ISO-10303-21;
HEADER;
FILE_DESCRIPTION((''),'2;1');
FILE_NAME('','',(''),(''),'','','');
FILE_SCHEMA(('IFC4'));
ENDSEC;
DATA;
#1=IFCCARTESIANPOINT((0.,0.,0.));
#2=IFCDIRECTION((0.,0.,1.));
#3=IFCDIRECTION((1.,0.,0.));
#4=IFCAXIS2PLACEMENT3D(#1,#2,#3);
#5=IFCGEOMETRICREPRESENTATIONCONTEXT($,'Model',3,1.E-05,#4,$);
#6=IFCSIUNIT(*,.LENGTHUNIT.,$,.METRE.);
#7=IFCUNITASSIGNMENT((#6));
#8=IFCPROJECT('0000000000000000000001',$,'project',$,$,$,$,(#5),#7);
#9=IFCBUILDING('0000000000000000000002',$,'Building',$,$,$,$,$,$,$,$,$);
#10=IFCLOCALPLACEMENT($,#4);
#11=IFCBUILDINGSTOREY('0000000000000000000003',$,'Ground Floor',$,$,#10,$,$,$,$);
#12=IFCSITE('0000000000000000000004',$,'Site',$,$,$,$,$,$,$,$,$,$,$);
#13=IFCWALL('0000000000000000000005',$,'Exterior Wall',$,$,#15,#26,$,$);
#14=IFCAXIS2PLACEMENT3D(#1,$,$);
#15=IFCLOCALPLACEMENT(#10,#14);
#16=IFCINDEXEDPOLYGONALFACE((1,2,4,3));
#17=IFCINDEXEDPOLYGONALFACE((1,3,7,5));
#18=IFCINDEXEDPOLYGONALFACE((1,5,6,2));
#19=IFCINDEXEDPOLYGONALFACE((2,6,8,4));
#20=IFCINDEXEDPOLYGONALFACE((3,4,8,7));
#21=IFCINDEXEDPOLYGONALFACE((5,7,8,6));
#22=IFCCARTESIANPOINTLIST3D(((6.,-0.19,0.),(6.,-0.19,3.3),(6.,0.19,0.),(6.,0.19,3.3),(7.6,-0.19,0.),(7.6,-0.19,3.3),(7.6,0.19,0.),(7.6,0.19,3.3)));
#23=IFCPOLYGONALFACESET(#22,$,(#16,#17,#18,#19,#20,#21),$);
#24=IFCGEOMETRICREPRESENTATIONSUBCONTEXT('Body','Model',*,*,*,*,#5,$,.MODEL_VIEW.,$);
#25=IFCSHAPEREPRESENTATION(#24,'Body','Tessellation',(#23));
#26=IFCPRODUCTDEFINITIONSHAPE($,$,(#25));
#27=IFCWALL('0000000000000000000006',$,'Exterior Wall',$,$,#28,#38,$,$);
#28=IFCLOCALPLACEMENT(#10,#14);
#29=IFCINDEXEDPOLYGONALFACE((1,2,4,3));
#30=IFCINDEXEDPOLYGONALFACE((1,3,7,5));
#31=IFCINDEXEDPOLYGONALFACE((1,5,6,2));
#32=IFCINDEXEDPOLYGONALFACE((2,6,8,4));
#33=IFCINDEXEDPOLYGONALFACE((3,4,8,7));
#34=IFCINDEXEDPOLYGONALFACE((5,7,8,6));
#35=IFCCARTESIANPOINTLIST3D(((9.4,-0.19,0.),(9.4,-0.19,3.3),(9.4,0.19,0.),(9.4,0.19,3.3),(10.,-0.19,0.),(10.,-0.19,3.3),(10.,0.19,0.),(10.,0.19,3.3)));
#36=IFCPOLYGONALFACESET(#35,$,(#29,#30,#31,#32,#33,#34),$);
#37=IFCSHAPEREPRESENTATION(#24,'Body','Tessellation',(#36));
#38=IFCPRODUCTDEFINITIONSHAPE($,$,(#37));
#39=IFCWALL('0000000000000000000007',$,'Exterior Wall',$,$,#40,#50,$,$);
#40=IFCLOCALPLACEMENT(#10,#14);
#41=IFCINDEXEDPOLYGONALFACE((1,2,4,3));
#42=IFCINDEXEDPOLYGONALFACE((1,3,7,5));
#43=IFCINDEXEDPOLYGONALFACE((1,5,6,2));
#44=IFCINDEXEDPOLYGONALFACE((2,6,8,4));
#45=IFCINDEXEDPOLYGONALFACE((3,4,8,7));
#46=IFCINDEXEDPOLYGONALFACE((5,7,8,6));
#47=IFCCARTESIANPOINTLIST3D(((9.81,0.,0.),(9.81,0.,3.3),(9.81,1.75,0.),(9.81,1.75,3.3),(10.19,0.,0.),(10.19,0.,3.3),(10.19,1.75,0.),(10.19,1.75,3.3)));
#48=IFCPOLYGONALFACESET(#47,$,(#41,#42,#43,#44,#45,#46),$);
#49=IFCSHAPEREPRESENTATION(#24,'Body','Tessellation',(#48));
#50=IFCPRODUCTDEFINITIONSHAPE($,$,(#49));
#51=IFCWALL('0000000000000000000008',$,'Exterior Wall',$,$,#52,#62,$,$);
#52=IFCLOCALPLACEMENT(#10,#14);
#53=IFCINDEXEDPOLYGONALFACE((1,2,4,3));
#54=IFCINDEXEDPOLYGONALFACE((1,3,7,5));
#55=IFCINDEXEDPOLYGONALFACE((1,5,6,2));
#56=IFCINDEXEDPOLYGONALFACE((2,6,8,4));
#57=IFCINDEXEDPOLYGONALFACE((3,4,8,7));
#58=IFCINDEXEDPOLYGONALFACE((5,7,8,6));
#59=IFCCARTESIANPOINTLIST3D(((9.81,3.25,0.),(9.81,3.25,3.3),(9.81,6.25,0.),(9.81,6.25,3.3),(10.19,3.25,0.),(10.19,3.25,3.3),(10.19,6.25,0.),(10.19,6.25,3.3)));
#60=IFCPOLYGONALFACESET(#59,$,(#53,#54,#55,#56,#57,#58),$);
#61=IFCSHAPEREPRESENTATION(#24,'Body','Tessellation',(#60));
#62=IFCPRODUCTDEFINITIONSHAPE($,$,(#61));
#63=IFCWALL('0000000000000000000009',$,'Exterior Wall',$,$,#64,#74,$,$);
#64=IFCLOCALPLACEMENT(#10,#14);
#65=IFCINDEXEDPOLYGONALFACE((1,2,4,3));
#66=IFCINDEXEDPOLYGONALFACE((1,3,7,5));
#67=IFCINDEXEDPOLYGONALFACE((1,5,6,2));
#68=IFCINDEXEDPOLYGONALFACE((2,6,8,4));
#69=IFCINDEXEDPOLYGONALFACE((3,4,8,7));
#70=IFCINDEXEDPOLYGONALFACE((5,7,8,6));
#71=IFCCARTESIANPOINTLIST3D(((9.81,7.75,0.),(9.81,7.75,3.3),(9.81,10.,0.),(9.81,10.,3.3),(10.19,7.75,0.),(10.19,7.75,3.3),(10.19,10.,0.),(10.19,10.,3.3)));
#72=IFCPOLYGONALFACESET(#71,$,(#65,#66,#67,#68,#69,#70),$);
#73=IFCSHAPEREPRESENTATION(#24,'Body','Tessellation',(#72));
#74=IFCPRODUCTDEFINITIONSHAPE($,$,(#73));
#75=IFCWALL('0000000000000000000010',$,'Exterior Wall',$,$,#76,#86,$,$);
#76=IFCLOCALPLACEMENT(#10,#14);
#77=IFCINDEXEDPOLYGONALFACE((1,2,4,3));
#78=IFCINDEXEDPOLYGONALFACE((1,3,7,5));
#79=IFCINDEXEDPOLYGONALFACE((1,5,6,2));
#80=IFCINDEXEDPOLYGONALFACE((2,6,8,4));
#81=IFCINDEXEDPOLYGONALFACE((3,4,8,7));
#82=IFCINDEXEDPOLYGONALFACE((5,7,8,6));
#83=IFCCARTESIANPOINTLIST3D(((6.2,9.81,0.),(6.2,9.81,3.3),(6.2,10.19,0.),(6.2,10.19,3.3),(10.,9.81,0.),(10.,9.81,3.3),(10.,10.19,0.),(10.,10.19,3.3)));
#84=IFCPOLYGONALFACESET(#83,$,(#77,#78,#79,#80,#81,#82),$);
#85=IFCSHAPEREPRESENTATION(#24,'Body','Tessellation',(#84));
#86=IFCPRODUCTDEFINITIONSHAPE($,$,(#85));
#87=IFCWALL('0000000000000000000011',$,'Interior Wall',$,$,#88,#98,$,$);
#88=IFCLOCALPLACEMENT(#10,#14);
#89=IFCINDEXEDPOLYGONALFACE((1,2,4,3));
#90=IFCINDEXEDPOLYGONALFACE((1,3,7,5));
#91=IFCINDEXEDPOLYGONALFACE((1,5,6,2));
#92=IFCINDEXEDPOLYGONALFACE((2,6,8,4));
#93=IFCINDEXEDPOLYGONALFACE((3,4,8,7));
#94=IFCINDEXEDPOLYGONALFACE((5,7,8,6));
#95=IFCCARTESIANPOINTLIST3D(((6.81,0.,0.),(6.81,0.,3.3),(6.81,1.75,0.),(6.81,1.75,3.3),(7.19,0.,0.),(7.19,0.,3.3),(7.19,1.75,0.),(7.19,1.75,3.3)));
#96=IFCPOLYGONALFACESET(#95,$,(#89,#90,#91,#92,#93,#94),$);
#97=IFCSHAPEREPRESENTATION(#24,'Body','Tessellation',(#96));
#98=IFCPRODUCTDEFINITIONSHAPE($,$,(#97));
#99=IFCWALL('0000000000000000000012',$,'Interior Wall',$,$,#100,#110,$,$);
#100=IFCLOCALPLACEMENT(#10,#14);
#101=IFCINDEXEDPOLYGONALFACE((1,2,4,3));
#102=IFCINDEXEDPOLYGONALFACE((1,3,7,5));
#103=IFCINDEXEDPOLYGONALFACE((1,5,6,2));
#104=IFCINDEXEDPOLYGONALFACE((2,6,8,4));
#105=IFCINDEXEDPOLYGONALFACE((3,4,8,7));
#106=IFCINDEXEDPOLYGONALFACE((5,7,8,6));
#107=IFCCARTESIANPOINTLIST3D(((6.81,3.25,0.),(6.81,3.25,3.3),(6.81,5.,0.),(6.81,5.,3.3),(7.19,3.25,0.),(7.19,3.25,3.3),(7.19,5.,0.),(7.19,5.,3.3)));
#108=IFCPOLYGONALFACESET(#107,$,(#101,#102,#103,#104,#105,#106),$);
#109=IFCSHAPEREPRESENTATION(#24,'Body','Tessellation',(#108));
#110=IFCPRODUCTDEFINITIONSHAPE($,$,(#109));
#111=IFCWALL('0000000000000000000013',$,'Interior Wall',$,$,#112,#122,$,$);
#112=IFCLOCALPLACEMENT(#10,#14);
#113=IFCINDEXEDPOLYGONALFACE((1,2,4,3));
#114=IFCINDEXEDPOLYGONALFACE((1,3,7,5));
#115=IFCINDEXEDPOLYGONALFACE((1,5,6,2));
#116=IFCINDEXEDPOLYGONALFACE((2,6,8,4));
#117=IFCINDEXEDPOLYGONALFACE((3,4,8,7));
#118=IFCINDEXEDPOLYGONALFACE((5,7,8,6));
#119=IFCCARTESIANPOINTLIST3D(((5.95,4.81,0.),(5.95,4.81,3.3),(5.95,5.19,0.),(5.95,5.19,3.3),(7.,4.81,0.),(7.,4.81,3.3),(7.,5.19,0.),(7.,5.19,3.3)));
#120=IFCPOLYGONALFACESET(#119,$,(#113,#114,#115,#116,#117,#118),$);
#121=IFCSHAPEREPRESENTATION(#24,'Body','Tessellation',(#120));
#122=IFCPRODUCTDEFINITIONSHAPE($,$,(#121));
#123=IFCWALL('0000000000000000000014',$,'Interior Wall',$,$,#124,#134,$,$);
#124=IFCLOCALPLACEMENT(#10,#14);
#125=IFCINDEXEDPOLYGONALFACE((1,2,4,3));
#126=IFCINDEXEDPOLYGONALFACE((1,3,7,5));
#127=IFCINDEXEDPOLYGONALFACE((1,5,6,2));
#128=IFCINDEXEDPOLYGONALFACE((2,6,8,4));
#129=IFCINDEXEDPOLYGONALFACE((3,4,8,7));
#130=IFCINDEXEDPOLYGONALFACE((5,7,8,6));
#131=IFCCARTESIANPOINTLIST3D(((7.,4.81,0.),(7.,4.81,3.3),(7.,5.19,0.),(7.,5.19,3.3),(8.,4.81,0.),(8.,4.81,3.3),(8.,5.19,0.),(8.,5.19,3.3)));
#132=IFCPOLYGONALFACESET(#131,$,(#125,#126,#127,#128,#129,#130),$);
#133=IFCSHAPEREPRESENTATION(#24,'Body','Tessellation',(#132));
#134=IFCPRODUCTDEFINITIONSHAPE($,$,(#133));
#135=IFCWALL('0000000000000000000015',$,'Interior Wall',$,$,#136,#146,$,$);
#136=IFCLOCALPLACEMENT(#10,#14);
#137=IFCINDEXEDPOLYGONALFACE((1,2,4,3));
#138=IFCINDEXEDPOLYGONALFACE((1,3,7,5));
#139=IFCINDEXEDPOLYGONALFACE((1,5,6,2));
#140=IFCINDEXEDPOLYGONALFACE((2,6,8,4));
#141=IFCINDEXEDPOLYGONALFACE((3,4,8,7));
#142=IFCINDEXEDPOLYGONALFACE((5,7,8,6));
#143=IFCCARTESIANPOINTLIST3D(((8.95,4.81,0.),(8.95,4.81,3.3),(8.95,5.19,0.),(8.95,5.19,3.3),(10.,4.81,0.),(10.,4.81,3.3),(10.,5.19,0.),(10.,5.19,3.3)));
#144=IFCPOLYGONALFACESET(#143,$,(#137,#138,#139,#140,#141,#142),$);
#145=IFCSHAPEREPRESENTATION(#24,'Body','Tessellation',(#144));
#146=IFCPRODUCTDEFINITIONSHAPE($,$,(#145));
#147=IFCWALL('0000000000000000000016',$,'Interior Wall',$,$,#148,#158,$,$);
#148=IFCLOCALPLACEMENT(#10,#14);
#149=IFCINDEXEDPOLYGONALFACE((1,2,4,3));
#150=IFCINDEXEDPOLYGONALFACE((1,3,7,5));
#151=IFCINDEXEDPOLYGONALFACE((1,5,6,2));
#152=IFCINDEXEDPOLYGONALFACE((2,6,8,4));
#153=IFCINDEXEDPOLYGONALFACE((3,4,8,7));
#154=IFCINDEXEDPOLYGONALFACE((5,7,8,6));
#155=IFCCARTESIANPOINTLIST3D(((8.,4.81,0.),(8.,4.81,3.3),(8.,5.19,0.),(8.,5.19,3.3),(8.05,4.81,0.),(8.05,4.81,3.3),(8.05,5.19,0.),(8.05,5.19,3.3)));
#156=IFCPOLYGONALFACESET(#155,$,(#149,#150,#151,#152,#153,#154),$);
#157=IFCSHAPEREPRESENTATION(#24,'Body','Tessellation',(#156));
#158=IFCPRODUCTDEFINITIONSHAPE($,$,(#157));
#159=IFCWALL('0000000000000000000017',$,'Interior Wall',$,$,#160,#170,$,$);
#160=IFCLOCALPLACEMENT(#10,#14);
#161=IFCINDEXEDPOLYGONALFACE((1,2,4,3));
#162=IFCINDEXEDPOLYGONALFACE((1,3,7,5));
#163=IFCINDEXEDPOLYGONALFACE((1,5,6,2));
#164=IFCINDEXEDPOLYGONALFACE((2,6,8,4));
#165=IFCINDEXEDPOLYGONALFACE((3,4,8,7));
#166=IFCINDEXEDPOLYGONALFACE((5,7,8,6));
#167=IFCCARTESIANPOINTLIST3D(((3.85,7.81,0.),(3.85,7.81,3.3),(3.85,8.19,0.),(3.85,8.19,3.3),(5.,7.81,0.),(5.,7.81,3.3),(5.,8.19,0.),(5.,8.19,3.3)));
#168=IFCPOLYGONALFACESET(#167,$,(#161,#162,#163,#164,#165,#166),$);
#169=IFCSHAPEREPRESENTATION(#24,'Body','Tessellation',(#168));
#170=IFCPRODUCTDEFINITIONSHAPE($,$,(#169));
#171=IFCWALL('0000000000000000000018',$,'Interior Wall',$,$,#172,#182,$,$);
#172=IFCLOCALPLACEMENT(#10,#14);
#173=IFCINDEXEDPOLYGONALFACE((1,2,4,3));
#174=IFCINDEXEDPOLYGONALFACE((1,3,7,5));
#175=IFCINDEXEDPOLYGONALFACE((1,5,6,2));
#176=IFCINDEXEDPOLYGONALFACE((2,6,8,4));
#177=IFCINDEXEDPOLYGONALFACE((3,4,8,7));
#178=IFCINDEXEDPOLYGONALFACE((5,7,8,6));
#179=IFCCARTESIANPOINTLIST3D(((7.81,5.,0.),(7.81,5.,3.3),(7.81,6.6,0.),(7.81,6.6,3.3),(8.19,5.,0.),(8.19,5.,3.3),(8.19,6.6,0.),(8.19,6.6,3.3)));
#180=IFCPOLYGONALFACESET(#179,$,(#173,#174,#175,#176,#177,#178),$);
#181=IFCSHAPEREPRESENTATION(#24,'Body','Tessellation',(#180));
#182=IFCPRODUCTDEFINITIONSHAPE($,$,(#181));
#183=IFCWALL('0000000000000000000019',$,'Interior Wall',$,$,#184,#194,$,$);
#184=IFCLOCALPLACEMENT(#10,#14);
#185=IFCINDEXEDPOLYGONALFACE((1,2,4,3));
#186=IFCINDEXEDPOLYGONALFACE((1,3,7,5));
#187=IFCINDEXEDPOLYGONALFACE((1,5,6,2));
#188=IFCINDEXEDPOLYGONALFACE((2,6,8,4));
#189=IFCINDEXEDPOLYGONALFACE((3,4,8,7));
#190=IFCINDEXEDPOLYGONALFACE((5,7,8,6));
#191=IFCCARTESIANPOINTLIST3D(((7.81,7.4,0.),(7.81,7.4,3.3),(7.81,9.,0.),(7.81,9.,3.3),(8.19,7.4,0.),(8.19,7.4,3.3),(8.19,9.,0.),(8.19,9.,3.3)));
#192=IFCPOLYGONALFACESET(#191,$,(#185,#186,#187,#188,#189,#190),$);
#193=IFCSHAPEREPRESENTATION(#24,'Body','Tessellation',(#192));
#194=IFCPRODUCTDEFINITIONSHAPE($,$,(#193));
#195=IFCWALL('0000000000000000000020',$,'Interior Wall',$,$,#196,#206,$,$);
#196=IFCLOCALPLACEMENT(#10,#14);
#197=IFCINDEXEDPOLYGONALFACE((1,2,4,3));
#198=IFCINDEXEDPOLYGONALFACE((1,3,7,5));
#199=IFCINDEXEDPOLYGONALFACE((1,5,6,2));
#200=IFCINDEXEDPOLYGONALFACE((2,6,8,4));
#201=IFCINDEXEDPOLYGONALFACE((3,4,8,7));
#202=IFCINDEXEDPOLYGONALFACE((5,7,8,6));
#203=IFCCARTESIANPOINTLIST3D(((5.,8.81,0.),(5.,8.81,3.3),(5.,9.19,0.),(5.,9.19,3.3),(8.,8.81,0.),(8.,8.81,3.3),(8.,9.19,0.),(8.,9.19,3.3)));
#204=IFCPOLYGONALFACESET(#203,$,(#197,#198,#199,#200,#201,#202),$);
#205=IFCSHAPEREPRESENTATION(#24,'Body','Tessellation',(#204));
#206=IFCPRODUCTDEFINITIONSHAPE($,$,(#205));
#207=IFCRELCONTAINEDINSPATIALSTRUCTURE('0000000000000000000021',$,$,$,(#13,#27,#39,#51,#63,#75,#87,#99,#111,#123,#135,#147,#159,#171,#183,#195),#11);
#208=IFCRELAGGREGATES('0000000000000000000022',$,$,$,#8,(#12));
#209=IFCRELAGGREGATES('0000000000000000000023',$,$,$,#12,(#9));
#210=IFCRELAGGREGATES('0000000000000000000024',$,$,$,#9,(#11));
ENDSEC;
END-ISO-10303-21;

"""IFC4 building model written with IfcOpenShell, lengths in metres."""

from ifc_helpers import new_model, si_unit, frame, origin_with_axes, place, context, subcontext, project, spatial, indexed_curve, outline, extrude, element, save


model = new_model("IFC4")

# Units and contexts
model_context = context("Model", 3, precision=1e-05, world=origin_with_axes())
body_context = subcontext(model_context, "Body", "Model", "MODEL_VIEW")
ifc_project = project(units=[si_unit("LENGTHUNIT", "METRE")], contexts=[model_context])

# Site, building, storey
site = spatial("IfcSite", under=ifc_project, Name="Site")
building = spatial("IfcBuilding", under=site, Name="Building")
storey_placement = place(None, origin_with_axes())
storey = spatial("IfcBuildingStorey", under=building, at=storey_placement, Name="Ground Floor")

# Walls
wall_1_placement = place(storey_placement, frame((6.0, 0.0, 0.0), z_axis=(0.0, 0.0, 1.0), x_axis=(1.0, 0.0, 0.0)))
element("IfcWall", 1, at=wall_1_placement, inside=storey, Name="Exterior Wall", context=body_context, shape_type="SweptSolid", body=[
    extrude(outline(indexed_curve([(0.0, 0.0), (0.0, 0.38), (1.6, 0.38), (1.6, 0.0), (0.0, 0.0)], self_intersect=False)), frame((0.0, -0.19, 0.0), z_axis=(0.0, 0.0, 1.0), x_axis=(1.0, 0.0, 0.0)), (0.0, 0.0, 1.0), 3.3),
])
wall_2_placement = place(storey_placement, frame((9.4, 0.0, 0.0), z_axis=(0.0, 0.0, 1.0), x_axis=(1.0, 0.0, 0.0)))
element("IfcWall", 2, at=wall_2_placement, inside=storey, Name="Exterior Wall", context=body_context, shape_type="SweptSolid", body=[
    extrude(outline(indexed_curve([(0.0, 0.0), (0.0, 0.38), (0.6, 0.38), (0.6, 0.0), (0.0, 0.0)], self_intersect=False)), frame((0.0, -0.19, 0.0), z_axis=(0.0, 0.0, 1.0), x_axis=(1.0, 0.0, 0.0)), (0.0, 0.0, 1.0), 3.3),
])
wall_3_placement = place(storey_placement, frame((10.0, 0.0, 0.0), z_axis=(0.0, 0.0, 1.0), x_axis=(0.0, 1.0, 0.0)))
element("IfcWall", 3, at=wall_3_placement, inside=storey, Name="Exterior Wall", context=body_context, shape_type="SweptSolid", body=[
    extrude(outline(indexed_curve([(0.0, 0.0), (0.0, 0.38), (1.75, 0.38), (1.75, 0.0), (0.0, 0.0)], self_intersect=False)), frame((0.0, -0.19, 0.0), z_axis=(0.0, 0.0, 1.0), x_axis=(1.0, 0.0, 0.0)), (0.0, 0.0, 1.0), 3.3),
])
wall_4_placement = place(storey_placement, frame((10.0, 3.25, 0.0), z_axis=(0.0, 0.0, 1.0), x_axis=(0.0, 1.0, 0.0)))
element("IfcWall", 4, at=wall_4_placement, inside=storey, Name="Exterior Wall", context=body_context, shape_type="SweptSolid", body=[
    extrude(outline(indexed_curve([(0.0, 0.0), (0.0, 0.38), (3.0, 0.38), (3.0, 0.0), (0.0, 0.0)], self_intersect=False)), frame((0.0, -0.19, 0.0), z_axis=(0.0, 0.0, 1.0), x_axis=(1.0, 0.0, 0.0)), (0.0, 0.0, 1.0), 3.3),
])
wall_5_placement = place(storey_placement, frame((10.0, 7.75, 0.0), z_axis=(0.0, 0.0, 1.0), x_axis=(0.0, 1.0, 0.0)))
element("IfcWall", 5, at=wall_5_placement, inside=storey, Name="Exterior Wall", context=body_context, shape_type="SweptSolid", body=[
    extrude(outline(indexed_curve([(0.0, 0.0), (0.0, 0.38), (2.25, 0.38), (2.25, 0.0), (0.0, 0.0)], self_intersect=False)), frame((0.0, -0.19, 0.0), z_axis=(0.0, 0.0, 1.0), x_axis=(1.0, 0.0, 0.0)), (0.0, 0.0, 1.0), 3.3),
])
wall_6_placement = place(storey_placement, frame((10.0, 10.0, 0.0), z_axis=(0.0, 0.0, 1.0), x_axis=(-1.0, 0.0, 0.0)))
element("IfcWall", 6, at=wall_6_placement, inside=storey, Name="Exterior Wall", context=body_context, shape_type="SweptSolid", body=[
    extrude(outline(indexed_curve([(0.0, 0.0), (0.0, 0.38), (3.8, 0.38), (3.8, 0.0), (0.0, 0.0)], self_intersect=False)), frame((0.0, -0.19, 0.0), z_axis=(0.0, 0.0, 1.0), x_axis=(1.0, 0.0, 0.0)), (0.0, 0.0, 1.0), 3.3),
])
for number, where, z_axis, x_axis, name in (
    (7, (7.0, 0.0, 0.0), (0.0, 0.0, 1.0), (0.0, 1.0, 0.0), "Interior Wall"),
    (8, (7.0, 3.25, 0.0), (0.0, 0.0, 1.0), (0.0, 1.0, 0.0), "Interior Wall"),
):
    element("IfcWall", number, at=place(storey_placement, frame(where, z_axis=z_axis, x_axis=x_axis)), inside=storey, Name=name, context=body_context, shape_type="SweptSolid", body=[
        extrude(outline(indexed_curve([(0.0, 0.0), (0.0, 0.38), (1.75, 0.38), (1.75, 0.0), (0.0, 0.0)], self_intersect=False)), frame((0.0, -0.19, 0.0), z_axis=(0.0, 0.0, 1.0), x_axis=(1.0, 0.0, 0.0)), (0.0, 0.0, 1.0), 3.3),
    ])
wall_7_placement = place(storey_placement, frame((7.0, 5.0, 0.0), z_axis=(0.0, 0.0, 1.0), x_axis=(-1.0, 0.0, 0.0)))
element("IfcWall", 9, at=wall_7_placement, inside=storey, Name="Interior Wall", context=body_context, shape_type="SweptSolid", body=[
    extrude(outline(indexed_curve([(0.0, 0.0), (0.0, 0.38), (1.05, 0.38), (1.05, 0.0), (0.0, 0.0)], self_intersect=False)), frame((0.0, -0.19, 0.0), z_axis=(0.0, 0.0, 1.0), x_axis=(1.0, 0.0, 0.0)), (0.0, 0.0, 1.0), 3.3),
])
wall_8_placement = place(storey_placement, frame((8.0, 5.0, 0.0), z_axis=(0.0, 0.0, 1.0), x_axis=(-1.0, 0.0, 0.0)))
element("IfcWall", 10, at=wall_8_placement, inside=storey, Name="Interior Wall", context=body_context, shape_type="SweptSolid", body=[
    extrude(outline(indexed_curve([(0.0, 0.0), (0.0, 0.38), (1.0, 0.38), (1.0, 0.0), (0.0, 0.0)], self_intersect=False)), frame((0.0, -0.19, 0.0), z_axis=(0.0, 0.0, 1.0), x_axis=(1.0, 0.0, 0.0)), (0.0, 0.0, 1.0), 3.3),
])
wall_9_placement = place(storey_placement, frame((10.0, 5.0, 0.0), z_axis=(0.0, 0.0, 1.0), x_axis=(-1.0, 0.0, 0.0)))
element("IfcWall", 11, at=wall_9_placement, inside=storey, Name="Interior Wall", context=body_context, shape_type="SweptSolid", body=[
    extrude(outline(indexed_curve([(0.0, 0.0), (0.0, 0.38), (1.05, 0.38), (1.05, 0.0), (0.0, 0.0)], self_intersect=False)), frame((0.0, -0.19, 0.0), z_axis=(0.0, 0.0, 1.0), x_axis=(1.0, 0.0, 0.0)), (0.0, 0.0, 1.0), 3.3),
])
wall_10_placement = place(storey_placement, frame((8.05, 5.0, 0.0), z_axis=(0.0, 0.0, 1.0), x_axis=(-1.0, 0.0, 0.0)))
element("IfcWall", 12, at=wall_10_placement, inside=storey, Name="Interior Wall", context=body_context, shape_type="SweptSolid", body=[
    extrude(outline(indexed_curve([(0.0, 0.0), (0.0, 0.38), (0.05, 0.38), (0.05, 0.0), (0.0, 0.0)], self_intersect=False)), frame((0.0, -0.19, 0.0), z_axis=(0.0, 0.0, 1.0), x_axis=(1.0, 0.0, 0.0)), (0.0, 0.0, 1.0), 3.3),
])
wall_11_placement = place(storey_placement, frame((5.0, 8.0, 0.0), z_axis=(0.0, 0.0, 1.0), x_axis=(-1.0, 0.0, 0.0)))
element("IfcWall", 13, at=wall_11_placement, inside=storey, Name="Interior Wall", context=body_context, shape_type="SweptSolid", body=[
    extrude(outline(indexed_curve([(0.0, 0.0), (0.0, 0.38), (1.15, 0.38), (1.15, 0.0), (0.0, 0.0)], self_intersect=False)), frame((0.0, -0.19, 0.0), z_axis=(0.0, 0.0, 1.0), x_axis=(1.0, 0.0, 0.0)), (0.0, 0.0, 1.0), 3.3),
])
for number, where, z_axis, x_axis, name in (
    (14, (8.0, 5.0, 0.0), (0.0, 0.0, 1.0), (0.0, 1.0, 0.0), "Interior Wall"),
    (15, (8.0, 7.4, 0.0), (0.0, 0.0, 1.0), (0.0, 1.0, 0.0), "Interior Wall"),
):
    element("IfcWall", number, at=place(storey_placement, frame(where, z_axis=z_axis, x_axis=x_axis)), inside=storey, Name=name, context=body_context, shape_type="SweptSolid", body=[
        extrude(outline(indexed_curve([(0.0, 0.0), (0.0, 0.38), (1.6, 0.38), (1.6, 0.0), (0.0, 0.0)], self_intersect=False)), frame((0.0, -0.19, 0.0), z_axis=(0.0, 0.0, 1.0), x_axis=(1.0, 0.0, 0.0)), (0.0, 0.0, 1.0), 3.3),
    ])
wall_12_placement = place(storey_placement, frame((8.0, 9.0, 0.0), z_axis=(0.0, 0.0, 1.0), x_axis=(-1.0, 0.0, 0.0)))
element("IfcWall", 16, at=wall_12_placement, inside=storey, Name="Interior Wall", context=body_context, shape_type="SweptSolid", body=[
    extrude(outline(indexed_curve([(0.0, 0.0), (0.0, 0.38), (3.0, 0.38), (3.0, 0.0), (0.0, 0.0)], self_intersect=False)), frame((0.0, -0.19, 0.0), z_axis=(0.0, 0.0, 1.0), x_axis=(1.0, 0.0, 0.0)), (0.0, 0.0, 1.0), 3.3),
])

save(model, "model.ifc")
